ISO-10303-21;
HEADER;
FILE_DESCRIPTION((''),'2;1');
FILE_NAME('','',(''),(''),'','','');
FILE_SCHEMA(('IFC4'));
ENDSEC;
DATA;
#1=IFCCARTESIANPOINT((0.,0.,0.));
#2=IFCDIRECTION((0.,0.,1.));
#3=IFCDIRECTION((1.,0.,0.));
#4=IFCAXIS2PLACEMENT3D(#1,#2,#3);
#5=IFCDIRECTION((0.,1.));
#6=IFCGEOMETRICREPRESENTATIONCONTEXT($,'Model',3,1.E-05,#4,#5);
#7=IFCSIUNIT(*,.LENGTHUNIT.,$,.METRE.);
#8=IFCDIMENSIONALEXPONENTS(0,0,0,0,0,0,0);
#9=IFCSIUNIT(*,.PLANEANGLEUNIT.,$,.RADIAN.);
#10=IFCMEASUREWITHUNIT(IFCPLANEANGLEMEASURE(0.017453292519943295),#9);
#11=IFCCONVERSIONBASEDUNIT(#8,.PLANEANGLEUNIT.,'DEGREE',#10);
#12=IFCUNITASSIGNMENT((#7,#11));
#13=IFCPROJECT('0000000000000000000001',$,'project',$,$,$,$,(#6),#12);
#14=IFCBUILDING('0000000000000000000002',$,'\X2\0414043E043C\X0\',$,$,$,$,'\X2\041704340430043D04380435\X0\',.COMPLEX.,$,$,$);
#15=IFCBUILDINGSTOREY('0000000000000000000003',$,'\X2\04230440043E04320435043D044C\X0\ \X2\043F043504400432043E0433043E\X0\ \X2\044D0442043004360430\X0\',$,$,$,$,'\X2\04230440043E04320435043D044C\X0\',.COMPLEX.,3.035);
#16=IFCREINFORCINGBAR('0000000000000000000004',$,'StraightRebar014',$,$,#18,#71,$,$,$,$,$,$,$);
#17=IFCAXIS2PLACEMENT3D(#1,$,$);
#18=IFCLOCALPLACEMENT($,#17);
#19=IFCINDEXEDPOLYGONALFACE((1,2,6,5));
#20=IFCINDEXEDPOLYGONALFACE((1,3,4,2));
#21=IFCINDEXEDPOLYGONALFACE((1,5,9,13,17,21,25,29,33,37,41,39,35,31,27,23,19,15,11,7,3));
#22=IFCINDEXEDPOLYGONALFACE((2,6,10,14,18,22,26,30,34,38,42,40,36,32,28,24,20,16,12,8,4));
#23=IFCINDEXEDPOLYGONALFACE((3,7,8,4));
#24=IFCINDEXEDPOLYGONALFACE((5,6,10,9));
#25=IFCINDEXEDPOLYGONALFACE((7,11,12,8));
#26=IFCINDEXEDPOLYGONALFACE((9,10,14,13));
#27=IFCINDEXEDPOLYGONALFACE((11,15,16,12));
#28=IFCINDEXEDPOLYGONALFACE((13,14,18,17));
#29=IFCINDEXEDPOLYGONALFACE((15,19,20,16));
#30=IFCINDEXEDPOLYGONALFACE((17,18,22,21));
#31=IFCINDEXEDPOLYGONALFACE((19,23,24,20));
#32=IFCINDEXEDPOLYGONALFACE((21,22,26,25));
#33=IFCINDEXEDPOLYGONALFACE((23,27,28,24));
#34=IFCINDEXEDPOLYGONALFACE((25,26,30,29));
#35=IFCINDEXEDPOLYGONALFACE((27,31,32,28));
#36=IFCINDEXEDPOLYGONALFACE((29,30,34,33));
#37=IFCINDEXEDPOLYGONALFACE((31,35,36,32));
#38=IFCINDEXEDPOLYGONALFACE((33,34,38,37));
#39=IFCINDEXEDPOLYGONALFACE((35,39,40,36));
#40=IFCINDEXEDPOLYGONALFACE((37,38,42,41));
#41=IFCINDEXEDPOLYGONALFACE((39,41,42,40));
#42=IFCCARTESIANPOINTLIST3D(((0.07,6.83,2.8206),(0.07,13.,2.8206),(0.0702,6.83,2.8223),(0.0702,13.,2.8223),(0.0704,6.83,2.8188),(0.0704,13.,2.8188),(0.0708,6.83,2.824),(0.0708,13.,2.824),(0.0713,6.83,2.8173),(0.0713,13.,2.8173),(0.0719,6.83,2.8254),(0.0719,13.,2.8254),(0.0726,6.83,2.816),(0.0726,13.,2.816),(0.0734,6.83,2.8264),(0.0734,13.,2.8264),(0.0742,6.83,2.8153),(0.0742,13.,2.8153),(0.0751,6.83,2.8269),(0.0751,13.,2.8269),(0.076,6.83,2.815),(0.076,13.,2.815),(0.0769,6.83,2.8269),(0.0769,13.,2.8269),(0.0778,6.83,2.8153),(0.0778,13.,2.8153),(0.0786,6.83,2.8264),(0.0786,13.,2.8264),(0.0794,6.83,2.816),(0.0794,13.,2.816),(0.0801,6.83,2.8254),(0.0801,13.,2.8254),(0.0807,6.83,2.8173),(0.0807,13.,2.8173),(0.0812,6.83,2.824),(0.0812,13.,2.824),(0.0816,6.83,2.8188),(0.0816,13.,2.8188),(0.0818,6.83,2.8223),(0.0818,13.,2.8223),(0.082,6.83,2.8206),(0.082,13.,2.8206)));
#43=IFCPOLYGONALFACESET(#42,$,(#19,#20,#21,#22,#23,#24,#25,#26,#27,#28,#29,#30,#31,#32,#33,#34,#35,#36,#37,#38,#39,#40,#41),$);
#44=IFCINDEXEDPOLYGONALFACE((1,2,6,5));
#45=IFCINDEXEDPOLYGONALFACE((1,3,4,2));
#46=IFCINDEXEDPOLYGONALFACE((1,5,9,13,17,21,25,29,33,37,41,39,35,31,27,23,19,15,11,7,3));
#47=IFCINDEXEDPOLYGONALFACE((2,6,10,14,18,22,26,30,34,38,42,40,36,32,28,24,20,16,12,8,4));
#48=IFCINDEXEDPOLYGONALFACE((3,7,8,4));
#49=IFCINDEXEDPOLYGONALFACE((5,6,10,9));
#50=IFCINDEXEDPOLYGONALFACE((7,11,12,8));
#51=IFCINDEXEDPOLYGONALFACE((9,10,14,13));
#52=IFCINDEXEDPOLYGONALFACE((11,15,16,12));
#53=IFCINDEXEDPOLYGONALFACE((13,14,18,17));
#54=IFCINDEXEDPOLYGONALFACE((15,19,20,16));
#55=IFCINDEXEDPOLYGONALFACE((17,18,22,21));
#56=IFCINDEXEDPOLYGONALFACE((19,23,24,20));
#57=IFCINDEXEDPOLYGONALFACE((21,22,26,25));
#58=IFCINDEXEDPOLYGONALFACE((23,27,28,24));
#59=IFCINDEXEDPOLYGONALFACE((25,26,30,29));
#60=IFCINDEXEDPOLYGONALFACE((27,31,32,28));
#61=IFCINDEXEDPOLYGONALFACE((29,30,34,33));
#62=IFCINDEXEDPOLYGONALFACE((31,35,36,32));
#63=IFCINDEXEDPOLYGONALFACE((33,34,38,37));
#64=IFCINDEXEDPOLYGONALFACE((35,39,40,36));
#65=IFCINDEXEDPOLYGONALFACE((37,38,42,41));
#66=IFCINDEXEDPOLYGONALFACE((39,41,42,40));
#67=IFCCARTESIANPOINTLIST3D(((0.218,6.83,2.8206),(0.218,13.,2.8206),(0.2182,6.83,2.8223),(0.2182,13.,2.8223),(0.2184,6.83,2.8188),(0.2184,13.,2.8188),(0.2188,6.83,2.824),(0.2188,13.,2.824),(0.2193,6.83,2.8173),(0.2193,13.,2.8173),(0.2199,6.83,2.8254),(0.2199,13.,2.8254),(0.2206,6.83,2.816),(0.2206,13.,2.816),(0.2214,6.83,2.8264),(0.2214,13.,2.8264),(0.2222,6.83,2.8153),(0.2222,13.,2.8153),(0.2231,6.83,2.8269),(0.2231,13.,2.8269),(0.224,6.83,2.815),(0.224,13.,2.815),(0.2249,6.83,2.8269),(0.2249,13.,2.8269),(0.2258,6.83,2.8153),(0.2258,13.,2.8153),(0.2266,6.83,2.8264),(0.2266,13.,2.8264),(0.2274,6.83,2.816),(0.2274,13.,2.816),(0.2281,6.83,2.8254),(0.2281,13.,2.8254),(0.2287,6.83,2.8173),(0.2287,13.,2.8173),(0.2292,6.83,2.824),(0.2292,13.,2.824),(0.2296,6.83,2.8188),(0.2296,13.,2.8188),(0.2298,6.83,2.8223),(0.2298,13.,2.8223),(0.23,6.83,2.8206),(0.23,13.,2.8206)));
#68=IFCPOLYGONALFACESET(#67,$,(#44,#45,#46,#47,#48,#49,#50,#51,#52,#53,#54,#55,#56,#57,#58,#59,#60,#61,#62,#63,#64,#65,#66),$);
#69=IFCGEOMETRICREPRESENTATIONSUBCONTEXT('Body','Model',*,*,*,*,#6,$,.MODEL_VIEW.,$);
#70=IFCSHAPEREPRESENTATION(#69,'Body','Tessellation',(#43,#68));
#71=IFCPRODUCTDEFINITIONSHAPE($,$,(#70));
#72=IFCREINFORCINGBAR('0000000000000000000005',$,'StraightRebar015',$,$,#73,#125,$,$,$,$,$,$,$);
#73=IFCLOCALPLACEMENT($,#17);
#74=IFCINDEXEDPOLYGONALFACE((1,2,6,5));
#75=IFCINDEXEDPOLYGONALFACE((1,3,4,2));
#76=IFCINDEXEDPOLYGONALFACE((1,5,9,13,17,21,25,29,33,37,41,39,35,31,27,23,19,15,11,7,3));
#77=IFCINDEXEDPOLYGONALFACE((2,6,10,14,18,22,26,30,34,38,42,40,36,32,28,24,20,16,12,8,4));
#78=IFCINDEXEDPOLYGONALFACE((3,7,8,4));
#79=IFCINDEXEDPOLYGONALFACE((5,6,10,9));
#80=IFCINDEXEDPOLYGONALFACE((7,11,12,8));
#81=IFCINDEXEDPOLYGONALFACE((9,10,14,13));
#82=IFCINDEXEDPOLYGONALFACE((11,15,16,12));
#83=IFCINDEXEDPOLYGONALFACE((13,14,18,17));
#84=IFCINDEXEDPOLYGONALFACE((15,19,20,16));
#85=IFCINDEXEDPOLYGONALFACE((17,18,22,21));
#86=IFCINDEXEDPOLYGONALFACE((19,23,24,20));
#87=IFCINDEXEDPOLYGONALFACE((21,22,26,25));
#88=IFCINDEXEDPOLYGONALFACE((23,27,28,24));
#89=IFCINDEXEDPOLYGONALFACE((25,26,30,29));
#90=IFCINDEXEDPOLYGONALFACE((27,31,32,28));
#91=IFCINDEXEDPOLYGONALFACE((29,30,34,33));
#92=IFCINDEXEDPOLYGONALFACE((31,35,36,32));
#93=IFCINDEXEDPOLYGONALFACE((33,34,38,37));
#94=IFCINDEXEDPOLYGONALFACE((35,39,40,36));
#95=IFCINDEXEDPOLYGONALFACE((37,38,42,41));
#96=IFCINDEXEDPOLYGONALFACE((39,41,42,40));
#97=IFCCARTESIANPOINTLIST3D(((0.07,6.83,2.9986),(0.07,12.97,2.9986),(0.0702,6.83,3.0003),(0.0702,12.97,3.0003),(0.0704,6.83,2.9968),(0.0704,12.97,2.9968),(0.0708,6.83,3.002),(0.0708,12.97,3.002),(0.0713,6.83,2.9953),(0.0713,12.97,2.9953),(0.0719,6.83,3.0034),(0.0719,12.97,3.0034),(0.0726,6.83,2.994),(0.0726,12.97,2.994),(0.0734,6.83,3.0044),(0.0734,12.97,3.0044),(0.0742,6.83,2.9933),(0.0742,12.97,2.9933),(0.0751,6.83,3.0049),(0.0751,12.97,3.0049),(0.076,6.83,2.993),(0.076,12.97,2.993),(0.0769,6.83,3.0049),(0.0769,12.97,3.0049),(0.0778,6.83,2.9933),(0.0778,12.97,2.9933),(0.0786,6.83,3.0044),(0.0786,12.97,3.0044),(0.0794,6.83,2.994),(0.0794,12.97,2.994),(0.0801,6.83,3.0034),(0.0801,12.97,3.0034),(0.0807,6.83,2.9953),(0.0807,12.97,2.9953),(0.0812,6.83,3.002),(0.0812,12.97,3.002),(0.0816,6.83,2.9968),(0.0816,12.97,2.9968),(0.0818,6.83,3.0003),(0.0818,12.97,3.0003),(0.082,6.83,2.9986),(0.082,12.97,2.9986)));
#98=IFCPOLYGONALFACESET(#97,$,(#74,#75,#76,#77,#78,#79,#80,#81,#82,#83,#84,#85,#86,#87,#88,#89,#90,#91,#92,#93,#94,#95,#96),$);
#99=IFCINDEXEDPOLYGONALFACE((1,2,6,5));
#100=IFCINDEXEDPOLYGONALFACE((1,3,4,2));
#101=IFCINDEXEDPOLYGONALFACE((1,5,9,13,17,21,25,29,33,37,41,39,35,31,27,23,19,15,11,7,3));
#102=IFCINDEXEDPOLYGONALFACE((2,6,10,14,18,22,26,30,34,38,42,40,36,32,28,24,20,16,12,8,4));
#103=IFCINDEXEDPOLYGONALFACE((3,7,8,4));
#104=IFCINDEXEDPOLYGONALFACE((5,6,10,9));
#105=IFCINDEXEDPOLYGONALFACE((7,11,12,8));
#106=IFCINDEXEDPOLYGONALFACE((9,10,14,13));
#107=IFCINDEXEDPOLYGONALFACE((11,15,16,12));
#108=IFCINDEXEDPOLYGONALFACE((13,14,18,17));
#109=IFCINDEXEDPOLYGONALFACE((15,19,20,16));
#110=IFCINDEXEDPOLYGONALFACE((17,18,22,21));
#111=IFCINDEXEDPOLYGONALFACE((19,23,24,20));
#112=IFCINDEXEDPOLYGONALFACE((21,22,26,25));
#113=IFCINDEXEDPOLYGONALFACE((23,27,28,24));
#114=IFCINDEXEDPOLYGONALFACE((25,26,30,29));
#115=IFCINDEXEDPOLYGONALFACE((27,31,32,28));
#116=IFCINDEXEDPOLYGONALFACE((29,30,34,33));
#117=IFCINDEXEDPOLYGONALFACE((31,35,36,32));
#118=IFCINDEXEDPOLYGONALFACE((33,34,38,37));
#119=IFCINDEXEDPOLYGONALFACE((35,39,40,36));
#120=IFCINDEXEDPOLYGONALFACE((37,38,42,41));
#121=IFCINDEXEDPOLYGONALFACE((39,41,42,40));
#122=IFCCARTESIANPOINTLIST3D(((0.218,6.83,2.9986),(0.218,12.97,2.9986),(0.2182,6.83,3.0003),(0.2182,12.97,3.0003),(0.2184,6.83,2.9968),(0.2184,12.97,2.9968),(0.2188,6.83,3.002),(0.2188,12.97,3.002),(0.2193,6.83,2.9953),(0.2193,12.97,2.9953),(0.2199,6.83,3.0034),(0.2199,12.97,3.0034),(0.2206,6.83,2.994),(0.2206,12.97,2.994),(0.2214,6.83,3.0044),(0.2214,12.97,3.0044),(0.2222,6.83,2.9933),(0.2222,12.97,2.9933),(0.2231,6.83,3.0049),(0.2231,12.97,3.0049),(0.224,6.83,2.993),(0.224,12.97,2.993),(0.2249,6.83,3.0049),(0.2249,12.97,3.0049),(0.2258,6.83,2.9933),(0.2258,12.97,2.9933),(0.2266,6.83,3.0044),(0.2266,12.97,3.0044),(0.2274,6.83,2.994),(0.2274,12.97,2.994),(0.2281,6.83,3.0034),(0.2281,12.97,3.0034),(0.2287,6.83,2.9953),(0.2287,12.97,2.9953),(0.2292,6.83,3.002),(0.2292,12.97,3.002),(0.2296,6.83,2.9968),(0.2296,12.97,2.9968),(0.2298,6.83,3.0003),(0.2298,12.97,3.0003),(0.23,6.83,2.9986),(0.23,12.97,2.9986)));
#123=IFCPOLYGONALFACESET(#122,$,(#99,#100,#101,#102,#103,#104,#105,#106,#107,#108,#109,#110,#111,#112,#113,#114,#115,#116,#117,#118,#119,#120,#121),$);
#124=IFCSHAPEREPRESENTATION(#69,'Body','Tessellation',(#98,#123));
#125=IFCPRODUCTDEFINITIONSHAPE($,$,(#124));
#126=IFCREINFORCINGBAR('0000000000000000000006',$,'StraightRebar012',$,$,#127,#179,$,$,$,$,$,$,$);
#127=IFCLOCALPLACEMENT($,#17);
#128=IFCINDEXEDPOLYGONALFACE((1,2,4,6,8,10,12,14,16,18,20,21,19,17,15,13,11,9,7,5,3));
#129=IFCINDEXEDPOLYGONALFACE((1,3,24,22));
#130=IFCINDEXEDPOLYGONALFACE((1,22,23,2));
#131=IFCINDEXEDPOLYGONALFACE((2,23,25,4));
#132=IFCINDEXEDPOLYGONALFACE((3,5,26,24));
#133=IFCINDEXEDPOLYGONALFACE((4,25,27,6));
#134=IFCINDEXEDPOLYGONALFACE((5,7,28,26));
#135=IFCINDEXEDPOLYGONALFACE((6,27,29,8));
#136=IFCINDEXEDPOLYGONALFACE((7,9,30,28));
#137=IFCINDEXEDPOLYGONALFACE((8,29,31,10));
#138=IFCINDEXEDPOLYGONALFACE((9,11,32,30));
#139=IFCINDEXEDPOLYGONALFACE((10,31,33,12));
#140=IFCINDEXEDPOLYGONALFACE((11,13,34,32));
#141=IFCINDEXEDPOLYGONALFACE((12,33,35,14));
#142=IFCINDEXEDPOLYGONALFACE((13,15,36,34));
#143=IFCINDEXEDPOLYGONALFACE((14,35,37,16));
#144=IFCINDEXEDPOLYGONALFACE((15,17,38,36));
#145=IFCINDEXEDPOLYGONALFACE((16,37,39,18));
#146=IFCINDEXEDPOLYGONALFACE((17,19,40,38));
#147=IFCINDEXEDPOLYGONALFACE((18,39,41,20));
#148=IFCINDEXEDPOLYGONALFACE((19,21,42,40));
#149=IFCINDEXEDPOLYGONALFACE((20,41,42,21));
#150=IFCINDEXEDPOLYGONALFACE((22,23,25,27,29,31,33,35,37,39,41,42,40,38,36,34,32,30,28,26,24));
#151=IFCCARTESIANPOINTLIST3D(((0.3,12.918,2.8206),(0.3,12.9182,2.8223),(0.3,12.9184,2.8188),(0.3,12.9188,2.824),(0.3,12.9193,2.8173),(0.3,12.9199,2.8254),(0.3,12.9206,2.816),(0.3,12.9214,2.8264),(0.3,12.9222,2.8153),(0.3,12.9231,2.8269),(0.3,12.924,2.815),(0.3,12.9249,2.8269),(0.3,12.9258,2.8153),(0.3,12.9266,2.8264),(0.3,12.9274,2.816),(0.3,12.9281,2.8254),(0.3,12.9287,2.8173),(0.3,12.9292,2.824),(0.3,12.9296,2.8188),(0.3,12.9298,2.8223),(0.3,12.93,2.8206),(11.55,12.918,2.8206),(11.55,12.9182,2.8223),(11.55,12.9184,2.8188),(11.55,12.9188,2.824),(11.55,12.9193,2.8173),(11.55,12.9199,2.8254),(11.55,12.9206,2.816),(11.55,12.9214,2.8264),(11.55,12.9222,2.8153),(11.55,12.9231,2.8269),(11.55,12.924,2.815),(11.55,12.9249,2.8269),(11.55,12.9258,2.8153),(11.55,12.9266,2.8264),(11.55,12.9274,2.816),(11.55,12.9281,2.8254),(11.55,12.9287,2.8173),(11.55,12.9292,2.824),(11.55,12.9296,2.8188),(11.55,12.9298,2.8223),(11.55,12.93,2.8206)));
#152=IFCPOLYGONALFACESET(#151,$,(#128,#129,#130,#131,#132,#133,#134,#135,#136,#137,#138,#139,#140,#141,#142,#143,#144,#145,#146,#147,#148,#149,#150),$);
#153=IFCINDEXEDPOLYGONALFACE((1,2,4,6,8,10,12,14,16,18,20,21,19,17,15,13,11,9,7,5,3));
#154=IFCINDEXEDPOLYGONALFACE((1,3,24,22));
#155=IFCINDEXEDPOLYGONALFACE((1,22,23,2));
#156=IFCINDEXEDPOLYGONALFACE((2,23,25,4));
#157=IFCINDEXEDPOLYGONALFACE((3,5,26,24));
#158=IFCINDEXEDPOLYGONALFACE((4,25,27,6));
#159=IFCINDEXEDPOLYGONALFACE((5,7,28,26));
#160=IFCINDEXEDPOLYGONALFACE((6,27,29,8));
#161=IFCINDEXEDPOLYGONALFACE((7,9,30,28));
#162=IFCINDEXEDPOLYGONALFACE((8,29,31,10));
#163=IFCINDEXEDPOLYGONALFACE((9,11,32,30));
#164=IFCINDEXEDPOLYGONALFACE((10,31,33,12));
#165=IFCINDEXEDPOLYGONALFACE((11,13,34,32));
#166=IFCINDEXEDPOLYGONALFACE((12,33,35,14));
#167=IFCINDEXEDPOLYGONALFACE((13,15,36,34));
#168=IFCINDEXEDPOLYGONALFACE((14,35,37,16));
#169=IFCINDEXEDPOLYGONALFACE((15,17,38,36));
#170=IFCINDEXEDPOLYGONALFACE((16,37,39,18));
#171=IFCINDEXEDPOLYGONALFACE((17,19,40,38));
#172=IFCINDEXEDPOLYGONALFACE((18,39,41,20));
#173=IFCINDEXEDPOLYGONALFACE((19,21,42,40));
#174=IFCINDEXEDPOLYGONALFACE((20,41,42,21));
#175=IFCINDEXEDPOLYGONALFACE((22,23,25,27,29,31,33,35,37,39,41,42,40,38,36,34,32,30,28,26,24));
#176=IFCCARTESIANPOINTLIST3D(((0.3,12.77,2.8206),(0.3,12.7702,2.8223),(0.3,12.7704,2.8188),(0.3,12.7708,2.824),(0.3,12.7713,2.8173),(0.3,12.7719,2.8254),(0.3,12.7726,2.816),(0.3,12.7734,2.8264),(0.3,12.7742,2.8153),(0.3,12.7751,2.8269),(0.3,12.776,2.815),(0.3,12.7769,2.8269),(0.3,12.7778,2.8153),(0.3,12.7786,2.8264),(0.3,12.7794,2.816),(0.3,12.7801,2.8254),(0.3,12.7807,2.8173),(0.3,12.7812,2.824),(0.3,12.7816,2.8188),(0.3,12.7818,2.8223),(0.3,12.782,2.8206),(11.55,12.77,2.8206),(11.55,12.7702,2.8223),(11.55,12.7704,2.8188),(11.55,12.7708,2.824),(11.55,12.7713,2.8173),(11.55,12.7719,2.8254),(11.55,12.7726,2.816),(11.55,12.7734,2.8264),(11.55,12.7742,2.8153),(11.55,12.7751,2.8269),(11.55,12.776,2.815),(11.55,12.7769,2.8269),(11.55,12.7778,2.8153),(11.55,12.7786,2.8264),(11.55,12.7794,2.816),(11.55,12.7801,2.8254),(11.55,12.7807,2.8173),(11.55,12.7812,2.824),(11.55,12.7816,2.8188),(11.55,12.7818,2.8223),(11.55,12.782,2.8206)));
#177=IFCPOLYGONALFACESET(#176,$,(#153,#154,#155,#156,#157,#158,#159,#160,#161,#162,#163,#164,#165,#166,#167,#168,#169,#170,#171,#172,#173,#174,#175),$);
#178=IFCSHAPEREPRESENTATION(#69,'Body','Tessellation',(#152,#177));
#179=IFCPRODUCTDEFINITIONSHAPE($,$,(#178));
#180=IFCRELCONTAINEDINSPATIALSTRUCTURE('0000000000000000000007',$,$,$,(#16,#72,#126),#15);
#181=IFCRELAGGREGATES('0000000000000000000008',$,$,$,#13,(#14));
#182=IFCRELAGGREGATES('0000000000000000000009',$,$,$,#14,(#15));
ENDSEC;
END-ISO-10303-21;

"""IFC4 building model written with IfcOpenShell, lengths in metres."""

from ifc_helpers import new_model, entity, si_unit, converted_unit, direction, origin_with_axes, place, context, subcontext, project, spatial, element, save


model = new_model("IFC4")

# Units and contexts
model_context = context("Model", 3, precision=1e-05, world=origin_with_axes(), true_north=direction((0.0, 1.0)))
body_context = subcontext(model_context, "Body", "Model", "MODEL_VIEW")
ifc_project = project(units=[si_unit("LENGTHUNIT", "METRE"), converted_unit("PLANEANGLEUNIT", "DEGREE", entity("IfcPlaneAngleMeasure", 0.017453292519943295), si_unit("PLANEANGLEUNIT", "RADIAN"), dimensions=[0, 0, 0, 0, 0, 0, 0])], contexts=[model_context])

# Building, storey
building = spatial("IfcBuilding", under=ifc_project, Name="Дом", LongName="Здание", CompositionType="COMPLEX")
storey = spatial("IfcBuildingStorey", under=building, Name="Уровень первого этажа", LongName="Уровень", CompositionType="COMPLEX", Elevation=3.035)

# Shared definitions
placement = place(None, origin_with_axes())

# Reinforcing bars
element("IfcReinforcingBar", 1, at=placement, inside=storey, Name="StraightRebar014", context=body_context, shape_type="SweptSolid", body=[
    entity("IfcSweptDiskSolid", entity("IfcCompositeCurve", [entity("IfcCompositeCurveSegment", "CONTINUOUS", True, entity("IfcPolyline", [entity("IfcCartesianPoint", [0.076, 13.0, 2.821]), entity("IfcCartesianPoint", [0.076, 6.83, 2.821])]))], False), 0.006),
    entity("IfcSweptDiskSolid", entity("IfcCompositeCurve", [entity("IfcCompositeCurveSegment", "CONTINUOUS", True, entity("IfcPolyline", [entity("IfcCartesianPoint", [0.224, 13.0, 2.821]), entity("IfcCartesianPoint", [0.224, 6.83, 2.821])]))], False), 0.006),
])
element("IfcReinforcingBar", 2, at=placement, inside=storey, Name="StraightRebar015", context=body_context, shape_type="SweptSolid", body=[
    entity("IfcSweptDiskSolid", entity("IfcCompositeCurve", [entity("IfcCompositeCurveSegment", "CONTINUOUS", True, entity("IfcPolyline", [entity("IfcCartesianPoint", [0.076, 12.97, 2.999]), entity("IfcCartesianPoint", [0.076, 6.83, 2.999])]))], False), 0.006),
    entity("IfcSweptDiskSolid", entity("IfcCompositeCurve", [entity("IfcCompositeCurveSegment", "CONTINUOUS", True, entity("IfcPolyline", [entity("IfcCartesianPoint", [0.224, 12.97, 2.999]), entity("IfcCartesianPoint", [0.224, 6.83, 2.999])]))], False), 0.006),
])
element("IfcReinforcingBar", 3, at=placement, inside=storey, Name="StraightRebar012", context=body_context, shape_type="SweptSolid", body=[
    entity("IfcSweptDiskSolid", entity("IfcCompositeCurve", [entity("IfcCompositeCurveSegment", "CONTINUOUS", True, entity("IfcPolyline", [entity("IfcCartesianPoint", [11.55, 12.924, 2.821]), entity("IfcCartesianPoint", [0.3, 12.924, 2.821])]))], False), 0.006),
    entity("IfcSweptDiskSolid", entity("IfcCompositeCurve", [entity("IfcCompositeCurveSegment", "CONTINUOUS", True, entity("IfcPolyline", [entity("IfcCartesianPoint", [11.55, 12.776, 2.821]), entity("IfcCartesianPoint", [0.3, 12.776, 2.821])]))], False), 0.006),
])

save(model, "model.ifc")
